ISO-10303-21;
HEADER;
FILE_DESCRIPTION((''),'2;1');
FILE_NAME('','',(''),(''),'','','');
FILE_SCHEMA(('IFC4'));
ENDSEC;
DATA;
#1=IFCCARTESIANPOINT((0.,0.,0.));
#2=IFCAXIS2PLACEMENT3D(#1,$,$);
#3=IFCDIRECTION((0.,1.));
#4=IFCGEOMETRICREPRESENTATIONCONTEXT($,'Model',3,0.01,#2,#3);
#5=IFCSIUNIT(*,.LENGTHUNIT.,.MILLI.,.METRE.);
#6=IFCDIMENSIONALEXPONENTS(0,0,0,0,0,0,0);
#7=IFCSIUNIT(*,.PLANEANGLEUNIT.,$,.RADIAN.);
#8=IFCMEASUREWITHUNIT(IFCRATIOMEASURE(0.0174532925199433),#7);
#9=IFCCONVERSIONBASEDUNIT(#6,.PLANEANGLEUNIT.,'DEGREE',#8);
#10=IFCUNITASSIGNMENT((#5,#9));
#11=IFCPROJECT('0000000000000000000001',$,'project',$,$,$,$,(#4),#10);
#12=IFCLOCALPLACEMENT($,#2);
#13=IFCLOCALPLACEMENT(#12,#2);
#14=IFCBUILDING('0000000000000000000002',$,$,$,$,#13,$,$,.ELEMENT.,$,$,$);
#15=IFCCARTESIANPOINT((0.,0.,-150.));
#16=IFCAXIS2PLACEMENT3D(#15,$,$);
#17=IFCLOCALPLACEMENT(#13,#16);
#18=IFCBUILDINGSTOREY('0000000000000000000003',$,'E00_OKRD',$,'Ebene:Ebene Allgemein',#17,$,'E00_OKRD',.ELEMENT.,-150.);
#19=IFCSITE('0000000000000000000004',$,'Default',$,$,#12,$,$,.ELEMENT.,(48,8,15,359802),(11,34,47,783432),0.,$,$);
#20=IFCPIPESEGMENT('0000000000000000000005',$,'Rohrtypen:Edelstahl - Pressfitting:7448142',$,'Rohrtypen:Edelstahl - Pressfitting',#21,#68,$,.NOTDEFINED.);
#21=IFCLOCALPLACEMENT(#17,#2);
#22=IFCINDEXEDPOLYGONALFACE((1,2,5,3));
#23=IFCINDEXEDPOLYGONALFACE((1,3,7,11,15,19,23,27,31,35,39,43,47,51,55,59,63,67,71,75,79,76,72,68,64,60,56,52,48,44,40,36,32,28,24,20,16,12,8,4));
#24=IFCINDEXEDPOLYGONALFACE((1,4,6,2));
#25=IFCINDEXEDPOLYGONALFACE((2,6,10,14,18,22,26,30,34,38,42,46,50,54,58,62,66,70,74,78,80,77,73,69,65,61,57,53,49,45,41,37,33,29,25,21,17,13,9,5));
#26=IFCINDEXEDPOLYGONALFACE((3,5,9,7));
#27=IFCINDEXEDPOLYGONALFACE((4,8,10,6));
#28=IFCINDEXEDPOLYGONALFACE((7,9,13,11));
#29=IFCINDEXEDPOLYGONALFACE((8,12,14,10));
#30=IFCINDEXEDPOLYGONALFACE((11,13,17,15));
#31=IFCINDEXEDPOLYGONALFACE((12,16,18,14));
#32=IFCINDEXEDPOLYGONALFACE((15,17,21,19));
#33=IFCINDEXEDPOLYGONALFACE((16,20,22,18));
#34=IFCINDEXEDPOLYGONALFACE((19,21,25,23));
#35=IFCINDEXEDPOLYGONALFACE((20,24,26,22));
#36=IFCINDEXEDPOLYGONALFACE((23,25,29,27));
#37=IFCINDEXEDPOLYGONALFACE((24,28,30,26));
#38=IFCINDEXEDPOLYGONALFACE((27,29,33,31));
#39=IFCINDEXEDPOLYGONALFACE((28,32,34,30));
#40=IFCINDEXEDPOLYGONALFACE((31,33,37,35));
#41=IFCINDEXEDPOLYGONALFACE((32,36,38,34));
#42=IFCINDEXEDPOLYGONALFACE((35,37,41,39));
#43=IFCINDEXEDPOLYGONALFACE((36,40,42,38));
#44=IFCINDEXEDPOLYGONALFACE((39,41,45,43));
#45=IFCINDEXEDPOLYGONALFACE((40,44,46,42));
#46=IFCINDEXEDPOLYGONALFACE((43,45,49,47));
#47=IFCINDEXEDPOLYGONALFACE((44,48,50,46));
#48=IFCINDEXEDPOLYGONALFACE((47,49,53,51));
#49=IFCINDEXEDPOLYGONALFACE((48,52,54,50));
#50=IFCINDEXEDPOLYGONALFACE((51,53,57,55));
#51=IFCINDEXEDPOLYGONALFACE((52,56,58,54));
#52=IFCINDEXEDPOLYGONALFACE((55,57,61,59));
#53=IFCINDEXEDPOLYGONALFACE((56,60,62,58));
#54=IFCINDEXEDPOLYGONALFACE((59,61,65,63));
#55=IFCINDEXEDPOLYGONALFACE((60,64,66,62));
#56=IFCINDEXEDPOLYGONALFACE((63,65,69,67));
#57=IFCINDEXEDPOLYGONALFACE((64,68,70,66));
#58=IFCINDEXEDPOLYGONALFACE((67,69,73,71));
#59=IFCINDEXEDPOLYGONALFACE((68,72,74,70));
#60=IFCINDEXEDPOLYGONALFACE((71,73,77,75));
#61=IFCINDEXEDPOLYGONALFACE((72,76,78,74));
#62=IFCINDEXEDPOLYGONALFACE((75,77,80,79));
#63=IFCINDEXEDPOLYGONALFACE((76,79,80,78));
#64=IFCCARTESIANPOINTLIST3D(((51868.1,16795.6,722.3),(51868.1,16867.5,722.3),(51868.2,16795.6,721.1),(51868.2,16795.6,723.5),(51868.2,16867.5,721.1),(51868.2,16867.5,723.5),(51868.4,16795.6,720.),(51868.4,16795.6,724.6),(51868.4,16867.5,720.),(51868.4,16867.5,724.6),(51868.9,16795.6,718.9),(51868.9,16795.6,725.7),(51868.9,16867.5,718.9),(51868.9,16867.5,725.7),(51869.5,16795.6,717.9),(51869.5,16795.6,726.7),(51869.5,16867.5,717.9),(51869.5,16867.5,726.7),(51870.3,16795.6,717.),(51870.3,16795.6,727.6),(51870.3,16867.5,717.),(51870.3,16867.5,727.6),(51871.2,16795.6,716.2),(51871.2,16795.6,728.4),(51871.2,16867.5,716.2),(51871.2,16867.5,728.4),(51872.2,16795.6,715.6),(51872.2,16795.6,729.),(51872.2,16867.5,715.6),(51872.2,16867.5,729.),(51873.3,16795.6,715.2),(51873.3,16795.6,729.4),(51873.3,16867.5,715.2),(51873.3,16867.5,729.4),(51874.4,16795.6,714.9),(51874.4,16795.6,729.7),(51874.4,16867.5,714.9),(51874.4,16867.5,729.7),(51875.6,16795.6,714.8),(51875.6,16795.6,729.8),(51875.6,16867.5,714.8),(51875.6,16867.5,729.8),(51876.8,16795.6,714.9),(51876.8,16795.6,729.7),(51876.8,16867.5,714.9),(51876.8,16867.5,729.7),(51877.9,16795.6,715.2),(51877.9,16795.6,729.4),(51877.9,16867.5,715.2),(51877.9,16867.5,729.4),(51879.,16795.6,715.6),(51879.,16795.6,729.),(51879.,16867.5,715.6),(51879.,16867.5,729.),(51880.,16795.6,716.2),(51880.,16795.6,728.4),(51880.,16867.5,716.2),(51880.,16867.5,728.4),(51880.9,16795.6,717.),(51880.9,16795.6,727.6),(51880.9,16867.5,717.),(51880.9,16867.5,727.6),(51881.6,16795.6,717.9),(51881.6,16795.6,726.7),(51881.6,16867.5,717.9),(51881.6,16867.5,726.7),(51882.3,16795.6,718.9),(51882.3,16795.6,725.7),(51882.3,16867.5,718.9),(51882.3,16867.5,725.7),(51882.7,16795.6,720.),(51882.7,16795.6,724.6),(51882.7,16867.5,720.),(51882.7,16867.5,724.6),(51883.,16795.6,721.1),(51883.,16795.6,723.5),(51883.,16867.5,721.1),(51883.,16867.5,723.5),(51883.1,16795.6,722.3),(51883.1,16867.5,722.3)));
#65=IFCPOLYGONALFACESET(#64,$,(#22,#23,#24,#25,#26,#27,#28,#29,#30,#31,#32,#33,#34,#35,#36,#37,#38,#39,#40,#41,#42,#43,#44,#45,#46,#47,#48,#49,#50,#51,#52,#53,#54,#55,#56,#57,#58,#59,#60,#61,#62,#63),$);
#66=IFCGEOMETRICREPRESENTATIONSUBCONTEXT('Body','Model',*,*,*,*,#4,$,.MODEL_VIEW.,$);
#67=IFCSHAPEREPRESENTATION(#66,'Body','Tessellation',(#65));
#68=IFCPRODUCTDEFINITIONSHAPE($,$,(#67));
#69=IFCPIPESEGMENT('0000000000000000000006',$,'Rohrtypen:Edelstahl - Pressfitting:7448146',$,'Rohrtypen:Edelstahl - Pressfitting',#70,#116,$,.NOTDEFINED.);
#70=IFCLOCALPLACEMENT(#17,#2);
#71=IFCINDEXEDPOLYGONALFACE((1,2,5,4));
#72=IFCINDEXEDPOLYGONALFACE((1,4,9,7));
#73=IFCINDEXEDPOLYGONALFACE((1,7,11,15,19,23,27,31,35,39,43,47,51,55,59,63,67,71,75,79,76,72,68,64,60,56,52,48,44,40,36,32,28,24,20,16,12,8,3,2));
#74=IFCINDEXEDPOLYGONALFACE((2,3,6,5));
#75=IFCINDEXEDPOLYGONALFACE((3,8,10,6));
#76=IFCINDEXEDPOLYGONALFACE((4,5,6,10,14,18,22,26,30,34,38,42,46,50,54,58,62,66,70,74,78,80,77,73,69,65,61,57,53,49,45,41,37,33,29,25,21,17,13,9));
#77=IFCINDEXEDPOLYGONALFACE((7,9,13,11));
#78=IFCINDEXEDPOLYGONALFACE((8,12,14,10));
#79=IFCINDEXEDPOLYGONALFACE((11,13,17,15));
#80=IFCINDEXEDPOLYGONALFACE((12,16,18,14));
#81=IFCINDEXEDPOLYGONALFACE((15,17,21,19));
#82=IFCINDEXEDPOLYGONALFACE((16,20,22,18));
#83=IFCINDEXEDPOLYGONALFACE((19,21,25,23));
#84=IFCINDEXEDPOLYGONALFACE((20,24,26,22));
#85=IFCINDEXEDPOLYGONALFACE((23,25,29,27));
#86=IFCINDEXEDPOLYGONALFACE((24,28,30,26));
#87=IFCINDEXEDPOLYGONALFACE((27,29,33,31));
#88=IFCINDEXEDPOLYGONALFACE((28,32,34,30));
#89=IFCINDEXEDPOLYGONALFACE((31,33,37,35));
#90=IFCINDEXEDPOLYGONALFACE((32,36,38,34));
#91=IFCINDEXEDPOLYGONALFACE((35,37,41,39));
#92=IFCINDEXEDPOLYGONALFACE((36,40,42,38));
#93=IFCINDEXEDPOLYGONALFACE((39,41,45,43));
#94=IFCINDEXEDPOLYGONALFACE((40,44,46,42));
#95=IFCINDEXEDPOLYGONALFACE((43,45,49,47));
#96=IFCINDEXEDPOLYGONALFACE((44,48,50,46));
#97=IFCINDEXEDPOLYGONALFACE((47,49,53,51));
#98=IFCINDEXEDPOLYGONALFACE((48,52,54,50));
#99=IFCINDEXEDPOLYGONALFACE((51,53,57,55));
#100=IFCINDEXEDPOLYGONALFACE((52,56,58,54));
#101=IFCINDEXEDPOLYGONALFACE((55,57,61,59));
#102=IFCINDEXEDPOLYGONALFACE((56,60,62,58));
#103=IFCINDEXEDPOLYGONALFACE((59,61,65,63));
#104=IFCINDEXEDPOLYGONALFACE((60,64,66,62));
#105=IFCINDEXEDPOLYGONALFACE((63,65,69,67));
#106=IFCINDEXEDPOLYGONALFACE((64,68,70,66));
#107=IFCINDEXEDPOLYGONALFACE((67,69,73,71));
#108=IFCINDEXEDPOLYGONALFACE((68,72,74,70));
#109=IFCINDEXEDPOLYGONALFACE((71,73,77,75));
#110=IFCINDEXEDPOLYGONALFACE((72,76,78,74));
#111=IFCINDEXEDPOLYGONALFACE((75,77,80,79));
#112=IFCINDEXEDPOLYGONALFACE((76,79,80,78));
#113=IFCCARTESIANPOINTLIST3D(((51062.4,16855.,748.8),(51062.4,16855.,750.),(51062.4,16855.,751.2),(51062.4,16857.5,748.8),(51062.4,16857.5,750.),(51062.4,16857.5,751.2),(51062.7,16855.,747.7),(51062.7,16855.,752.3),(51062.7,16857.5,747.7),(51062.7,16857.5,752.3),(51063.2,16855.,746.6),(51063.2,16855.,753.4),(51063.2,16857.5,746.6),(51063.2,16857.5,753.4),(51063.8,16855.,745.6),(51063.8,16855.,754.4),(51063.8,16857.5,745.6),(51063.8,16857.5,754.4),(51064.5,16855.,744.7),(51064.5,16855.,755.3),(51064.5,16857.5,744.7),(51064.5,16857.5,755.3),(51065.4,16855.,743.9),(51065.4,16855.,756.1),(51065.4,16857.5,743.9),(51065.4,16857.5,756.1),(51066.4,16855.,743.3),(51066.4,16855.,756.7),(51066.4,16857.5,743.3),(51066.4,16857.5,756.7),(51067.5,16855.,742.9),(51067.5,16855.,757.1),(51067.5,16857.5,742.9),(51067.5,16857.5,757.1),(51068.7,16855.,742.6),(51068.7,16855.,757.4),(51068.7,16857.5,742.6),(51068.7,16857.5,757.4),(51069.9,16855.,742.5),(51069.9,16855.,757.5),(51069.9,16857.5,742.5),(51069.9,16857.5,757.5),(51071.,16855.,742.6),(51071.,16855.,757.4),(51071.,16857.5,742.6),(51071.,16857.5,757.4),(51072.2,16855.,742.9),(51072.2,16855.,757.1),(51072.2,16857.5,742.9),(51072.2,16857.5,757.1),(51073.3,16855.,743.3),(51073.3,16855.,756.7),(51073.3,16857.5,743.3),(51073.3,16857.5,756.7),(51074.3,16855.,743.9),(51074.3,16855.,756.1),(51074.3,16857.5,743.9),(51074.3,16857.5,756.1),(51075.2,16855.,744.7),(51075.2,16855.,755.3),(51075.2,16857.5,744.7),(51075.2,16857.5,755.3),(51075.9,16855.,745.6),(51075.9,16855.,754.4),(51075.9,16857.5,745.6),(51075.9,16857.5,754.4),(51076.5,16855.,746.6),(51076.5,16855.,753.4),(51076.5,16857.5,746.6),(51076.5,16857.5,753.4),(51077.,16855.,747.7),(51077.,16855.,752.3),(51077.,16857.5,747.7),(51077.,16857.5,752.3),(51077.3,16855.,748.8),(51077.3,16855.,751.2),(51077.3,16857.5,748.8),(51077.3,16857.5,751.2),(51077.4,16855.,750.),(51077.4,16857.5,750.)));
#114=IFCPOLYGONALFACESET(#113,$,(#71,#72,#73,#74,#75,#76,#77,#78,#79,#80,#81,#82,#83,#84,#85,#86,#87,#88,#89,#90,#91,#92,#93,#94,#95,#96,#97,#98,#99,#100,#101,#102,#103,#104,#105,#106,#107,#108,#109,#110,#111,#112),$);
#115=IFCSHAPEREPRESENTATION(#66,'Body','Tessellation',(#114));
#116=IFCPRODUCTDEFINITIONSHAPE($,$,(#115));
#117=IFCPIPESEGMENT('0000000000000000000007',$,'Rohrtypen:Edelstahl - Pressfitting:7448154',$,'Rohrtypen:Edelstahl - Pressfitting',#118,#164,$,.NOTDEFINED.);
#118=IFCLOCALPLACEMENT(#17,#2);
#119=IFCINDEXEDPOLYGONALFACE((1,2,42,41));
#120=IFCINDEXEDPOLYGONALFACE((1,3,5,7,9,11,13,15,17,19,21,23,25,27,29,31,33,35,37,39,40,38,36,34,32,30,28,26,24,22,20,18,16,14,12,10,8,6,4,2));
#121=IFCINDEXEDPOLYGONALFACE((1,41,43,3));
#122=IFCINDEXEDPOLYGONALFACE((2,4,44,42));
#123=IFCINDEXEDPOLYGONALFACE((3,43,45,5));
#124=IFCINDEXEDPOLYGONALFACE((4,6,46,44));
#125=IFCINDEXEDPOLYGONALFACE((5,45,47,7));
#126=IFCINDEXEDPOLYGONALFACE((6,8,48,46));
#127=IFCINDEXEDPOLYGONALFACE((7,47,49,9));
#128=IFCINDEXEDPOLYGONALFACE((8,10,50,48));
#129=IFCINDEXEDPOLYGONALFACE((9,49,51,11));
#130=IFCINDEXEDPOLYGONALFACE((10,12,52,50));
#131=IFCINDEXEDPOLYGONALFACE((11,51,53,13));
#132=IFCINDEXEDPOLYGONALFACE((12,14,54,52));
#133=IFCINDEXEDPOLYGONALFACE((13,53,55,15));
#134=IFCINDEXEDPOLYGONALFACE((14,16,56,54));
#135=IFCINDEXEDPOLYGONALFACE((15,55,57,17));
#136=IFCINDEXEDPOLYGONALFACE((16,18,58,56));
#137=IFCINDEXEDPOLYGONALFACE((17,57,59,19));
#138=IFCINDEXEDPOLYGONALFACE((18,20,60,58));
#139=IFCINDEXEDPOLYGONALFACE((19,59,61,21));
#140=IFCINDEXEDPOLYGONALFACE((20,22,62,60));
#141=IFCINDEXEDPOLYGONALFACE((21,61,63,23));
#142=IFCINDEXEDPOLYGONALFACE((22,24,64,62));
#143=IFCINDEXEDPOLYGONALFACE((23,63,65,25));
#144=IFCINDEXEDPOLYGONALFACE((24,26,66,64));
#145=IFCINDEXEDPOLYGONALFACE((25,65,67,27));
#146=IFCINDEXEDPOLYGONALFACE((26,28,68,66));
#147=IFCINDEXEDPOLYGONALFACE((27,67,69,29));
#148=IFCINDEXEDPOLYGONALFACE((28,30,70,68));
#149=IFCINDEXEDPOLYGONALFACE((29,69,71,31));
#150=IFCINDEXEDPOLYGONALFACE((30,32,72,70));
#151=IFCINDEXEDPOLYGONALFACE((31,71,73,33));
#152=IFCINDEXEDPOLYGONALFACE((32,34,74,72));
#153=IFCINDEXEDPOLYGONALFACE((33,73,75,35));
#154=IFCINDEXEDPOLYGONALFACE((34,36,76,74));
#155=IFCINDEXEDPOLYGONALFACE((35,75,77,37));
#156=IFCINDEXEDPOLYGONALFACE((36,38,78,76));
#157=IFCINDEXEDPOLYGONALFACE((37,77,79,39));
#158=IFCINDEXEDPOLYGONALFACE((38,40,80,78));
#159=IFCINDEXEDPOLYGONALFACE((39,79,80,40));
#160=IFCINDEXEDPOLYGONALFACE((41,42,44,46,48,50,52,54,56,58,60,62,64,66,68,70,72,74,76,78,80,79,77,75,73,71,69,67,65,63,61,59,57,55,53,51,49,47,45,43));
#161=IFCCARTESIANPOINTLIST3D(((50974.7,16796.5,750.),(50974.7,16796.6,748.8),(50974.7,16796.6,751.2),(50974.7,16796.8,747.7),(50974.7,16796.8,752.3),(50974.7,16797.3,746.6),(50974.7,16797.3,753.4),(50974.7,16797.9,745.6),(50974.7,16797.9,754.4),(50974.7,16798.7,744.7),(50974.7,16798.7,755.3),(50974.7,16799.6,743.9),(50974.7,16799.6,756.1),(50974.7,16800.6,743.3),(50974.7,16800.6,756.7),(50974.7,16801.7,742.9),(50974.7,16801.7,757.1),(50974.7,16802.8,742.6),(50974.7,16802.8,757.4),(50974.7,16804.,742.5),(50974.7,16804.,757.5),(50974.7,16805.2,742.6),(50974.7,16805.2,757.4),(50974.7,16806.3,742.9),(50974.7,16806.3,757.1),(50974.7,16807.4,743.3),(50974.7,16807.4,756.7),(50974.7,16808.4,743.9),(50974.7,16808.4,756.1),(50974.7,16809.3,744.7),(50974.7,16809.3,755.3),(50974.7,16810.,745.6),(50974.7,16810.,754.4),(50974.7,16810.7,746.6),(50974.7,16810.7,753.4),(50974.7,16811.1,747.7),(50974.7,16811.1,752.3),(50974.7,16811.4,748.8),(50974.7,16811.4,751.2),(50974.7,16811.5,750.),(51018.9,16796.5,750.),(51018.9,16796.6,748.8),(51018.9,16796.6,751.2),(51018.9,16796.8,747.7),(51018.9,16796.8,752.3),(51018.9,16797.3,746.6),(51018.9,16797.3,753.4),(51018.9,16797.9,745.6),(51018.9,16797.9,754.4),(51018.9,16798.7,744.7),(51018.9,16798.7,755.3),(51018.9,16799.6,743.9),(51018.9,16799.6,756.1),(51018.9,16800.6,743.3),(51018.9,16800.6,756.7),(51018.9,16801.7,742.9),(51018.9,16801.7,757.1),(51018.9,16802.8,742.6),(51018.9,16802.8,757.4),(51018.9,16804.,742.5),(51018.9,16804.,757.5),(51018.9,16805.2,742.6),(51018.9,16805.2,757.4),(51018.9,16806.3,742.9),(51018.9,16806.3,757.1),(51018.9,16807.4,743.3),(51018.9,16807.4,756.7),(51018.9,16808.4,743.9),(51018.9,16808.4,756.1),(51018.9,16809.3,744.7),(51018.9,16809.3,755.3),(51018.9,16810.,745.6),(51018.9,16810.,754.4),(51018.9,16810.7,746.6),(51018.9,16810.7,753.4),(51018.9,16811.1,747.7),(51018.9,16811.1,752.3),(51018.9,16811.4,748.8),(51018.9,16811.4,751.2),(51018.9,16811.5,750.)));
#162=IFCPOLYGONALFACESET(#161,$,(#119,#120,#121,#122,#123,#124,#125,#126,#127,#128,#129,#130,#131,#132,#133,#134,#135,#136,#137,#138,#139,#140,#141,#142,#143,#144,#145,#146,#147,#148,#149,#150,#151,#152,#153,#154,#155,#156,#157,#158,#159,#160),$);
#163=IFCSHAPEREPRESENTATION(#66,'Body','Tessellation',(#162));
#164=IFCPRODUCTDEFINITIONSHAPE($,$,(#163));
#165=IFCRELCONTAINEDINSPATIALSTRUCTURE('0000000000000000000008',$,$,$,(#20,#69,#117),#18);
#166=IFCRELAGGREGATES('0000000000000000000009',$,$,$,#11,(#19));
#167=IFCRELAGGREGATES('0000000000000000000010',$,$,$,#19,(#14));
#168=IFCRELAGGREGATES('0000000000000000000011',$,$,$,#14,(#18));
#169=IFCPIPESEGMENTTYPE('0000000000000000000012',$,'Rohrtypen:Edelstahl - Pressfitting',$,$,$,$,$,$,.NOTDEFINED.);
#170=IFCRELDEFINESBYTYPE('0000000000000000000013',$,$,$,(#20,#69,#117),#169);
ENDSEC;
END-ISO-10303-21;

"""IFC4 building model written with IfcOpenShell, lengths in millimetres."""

from ifc_helpers import new_model, entity, si_unit, converted_unit, direction, frame, origin, place, context, subcontext, project, spatial, indexed_curve, outline, extrude, type_object, element, save


model = new_model("IFC4")

# Units and contexts
model_context = context("Model", 3, precision=0.01, world=origin(), true_north=direction((0.0, 1.0)))
body_context = subcontext(model_context, "Body", "Model", "MODEL_VIEW")
ifc_project = project(units=[si_unit("LENGTHUNIT", "METRE", prefix="MILLI"), converted_unit("PLANEANGLEUNIT", "DEGREE", entity("IfcRatioMeasure", 0.0174532925199433), si_unit("PLANEANGLEUNIT", "RADIAN"), dimensions=[0, 0, 0, 0, 0, 0, 0])], contexts=[model_context])

# Site, building, storey
site_placement = place(None, origin())
site = spatial("IfcSite", under=ifc_project, at=site_placement, Name="Default", CompositionType="ELEMENT", RefLatitude=(48, 8, 15, 359802), RefLongitude=(11, 34, 47, 783432), RefElevation=0.0)
building_placement = place(site_placement, origin())
building = spatial("IfcBuilding", under=site, at=building_placement, CompositionType="ELEMENT")
storey_placement = place(building_placement, frame((0.0, 0.0, -150.0)))
storey = spatial("IfcBuildingStorey", under=building, at=storey_placement, Name="E00_OKRD", ObjectType="Ebene:Ebene Allgemein", LongName="E00_OKRD", CompositionType="ELEMENT", Elevation=-150.0)

# Pipe segments
pipe_segment_type_1 = type_object("IfcPipeSegmentType", Name="Rohrtypen:Edelstahl - Pressfitting", PredefinedType="NOTDEFINED")
pipe_segment_1_placement = place(storey_placement, origin())
element("IfcPipeSegment", 1, at=pipe_segment_1_placement, inside=storey, type_object=pipe_segment_type_1, Name="Rohrtypen:Edelstahl - Pressfitting:7448142", ObjectType="Rohrtypen:Edelstahl - Pressfitting", PredefinedType="NOTDEFINED", context=body_context, shape_type="SweptSolid", body=[
    extrude(outline(indexed_curve([(7.5, 0.0), (7.4, 1.2), (7.1, 2.3), (6.7, 3.4), (6.1, 4.4), (5.3, 5.3), (4.4, 6.1), (3.4, 6.7), (2.3, 7.1), (1.2, 7.4), (0.0, 7.5), (-1.2, 7.4), (-2.3, 7.1), (-3.4, 6.7), (-4.4, 6.1), (-5.3, 5.3), (-6.1, 4.4), (-6.7, 3.4), (-7.1, 2.3), (-7.4, 1.2), (-7.5, 0.0), (-7.4, -1.2), (-7.1, -2.3), (-6.7, -3.4), (-6.1, -4.4), (-5.3, -5.3), (-4.4, -6.1), (-3.4, -6.7), (-2.3, -7.1), (-1.2, -7.4), (0.0, -7.5), (1.2, -7.4), (2.3, -7.1), (3.4, -6.7), (4.4, -6.1), (5.3, -5.3), (6.1, -4.4), (6.7, -3.4), (7.1, -2.3), (7.4, -1.2), (7.5, 0.0)], self_intersect=False)), frame((51875.6, 16795.6, 722.3), z_axis=(0.0, 1.0, 0.0), x_axis=(-1.0, 0.0, 0.0)), (0.0, 0.0, 1.0), 71.9),
])
pipe_segment_2_placement = place(storey_placement, origin())
element("IfcPipeSegment", 2, at=pipe_segment_2_placement, inside=storey, type_object=pipe_segment_type_1, Name="Rohrtypen:Edelstahl - Pressfitting:7448146", ObjectType="Rohrtypen:Edelstahl - Pressfitting", PredefinedType="NOTDEFINED", context=body_context, shape_type="SweptSolid", body=[
    extrude(outline(indexed_curve([(7.5, 0.0), (7.4, 1.2), (7.1, 2.3), (6.7, 3.4), (6.1, 4.4), (5.3, 5.3), (4.4, 6.1), (3.4, 6.7), (2.3, 7.1), (1.2, 7.4), (0.0, 7.5), (-1.2, 7.4), (-2.3, 7.1), (-3.4, 6.7), (-4.4, 6.1), (-5.3, 5.3), (-6.1, 4.4), (-6.7, 3.4), (-7.1, 2.3), (-7.4, 1.2), (-7.5, 0.0), (-7.4, -1.2), (-7.1, -2.3), (-6.7, -3.4), (-6.1, -4.4), (-5.3, -5.3), (-4.4, -6.1), (-3.4, -6.7), (-2.3, -7.1), (-1.2, -7.4), (0.0, -7.5), (1.2, -7.4), (2.3, -7.1), (3.4, -6.7), (4.4, -6.1), (5.3, -5.3), (6.1, -4.4), (6.7, -3.4), (7.1, -2.3), (7.4, -1.2), (7.5, 0.0)], self_intersect=False)), frame((51069.9, 16855.0, 750.0), z_axis=(0.0, 1.0, 0.0), x_axis=(-1.0, 0.0, 0.0)), (0.0, 0.0, 1.0), 2.6),
])
pipe_segment_3_placement = place(storey_placement, origin())
element("IfcPipeSegment", 3, at=pipe_segment_3_placement, inside=storey, type_object=pipe_segment_type_1, Name="Rohrtypen:Edelstahl - Pressfitting:7448154", ObjectType="Rohrtypen:Edelstahl - Pressfitting", PredefinedType="NOTDEFINED", context=body_context, shape_type="SweptSolid", body=[
    extrude(outline(indexed_curve([(7.5, 0.0), (7.4, 1.2), (7.1, 2.3), (6.7, 3.4), (6.1, 4.4), (5.3, 5.3), (4.4, 6.1), (3.4, 6.7), (2.3, 7.1), (1.2, 7.4), (0.0, 7.5), (-1.2, 7.4), (-2.3, 7.1), (-3.4, 6.7), (-4.4, 6.1), (-5.3, 5.3), (-6.1, 4.4), (-6.7, 3.4), (-7.1, 2.3), (-7.4, 1.2), (-7.5, 0.0), (-7.4, -1.2), (-7.1, -2.3), (-6.7, -3.4), (-6.1, -4.4), (-5.3, -5.3), (-4.4, -6.1), (-3.4, -6.7), (-2.3, -7.1), (-1.2, -7.4), (0.0, -7.5), (1.2, -7.4), (2.3, -7.1), (3.4, -6.7), (4.4, -6.1), (5.3, -5.3), (6.1, -4.4), (6.7, -3.4), (7.1, -2.3), (7.4, -1.2), (7.5, 0.0)], self_intersect=False)), frame((50974.7, 16804.0, 750.0), z_axis=(1.0, 0.0, 0.0), x_axis=(0.0, 1.0, 0.0)), (0.0, 0.0, 1.0), 44.2),
])

save(model, "model.ifc")
